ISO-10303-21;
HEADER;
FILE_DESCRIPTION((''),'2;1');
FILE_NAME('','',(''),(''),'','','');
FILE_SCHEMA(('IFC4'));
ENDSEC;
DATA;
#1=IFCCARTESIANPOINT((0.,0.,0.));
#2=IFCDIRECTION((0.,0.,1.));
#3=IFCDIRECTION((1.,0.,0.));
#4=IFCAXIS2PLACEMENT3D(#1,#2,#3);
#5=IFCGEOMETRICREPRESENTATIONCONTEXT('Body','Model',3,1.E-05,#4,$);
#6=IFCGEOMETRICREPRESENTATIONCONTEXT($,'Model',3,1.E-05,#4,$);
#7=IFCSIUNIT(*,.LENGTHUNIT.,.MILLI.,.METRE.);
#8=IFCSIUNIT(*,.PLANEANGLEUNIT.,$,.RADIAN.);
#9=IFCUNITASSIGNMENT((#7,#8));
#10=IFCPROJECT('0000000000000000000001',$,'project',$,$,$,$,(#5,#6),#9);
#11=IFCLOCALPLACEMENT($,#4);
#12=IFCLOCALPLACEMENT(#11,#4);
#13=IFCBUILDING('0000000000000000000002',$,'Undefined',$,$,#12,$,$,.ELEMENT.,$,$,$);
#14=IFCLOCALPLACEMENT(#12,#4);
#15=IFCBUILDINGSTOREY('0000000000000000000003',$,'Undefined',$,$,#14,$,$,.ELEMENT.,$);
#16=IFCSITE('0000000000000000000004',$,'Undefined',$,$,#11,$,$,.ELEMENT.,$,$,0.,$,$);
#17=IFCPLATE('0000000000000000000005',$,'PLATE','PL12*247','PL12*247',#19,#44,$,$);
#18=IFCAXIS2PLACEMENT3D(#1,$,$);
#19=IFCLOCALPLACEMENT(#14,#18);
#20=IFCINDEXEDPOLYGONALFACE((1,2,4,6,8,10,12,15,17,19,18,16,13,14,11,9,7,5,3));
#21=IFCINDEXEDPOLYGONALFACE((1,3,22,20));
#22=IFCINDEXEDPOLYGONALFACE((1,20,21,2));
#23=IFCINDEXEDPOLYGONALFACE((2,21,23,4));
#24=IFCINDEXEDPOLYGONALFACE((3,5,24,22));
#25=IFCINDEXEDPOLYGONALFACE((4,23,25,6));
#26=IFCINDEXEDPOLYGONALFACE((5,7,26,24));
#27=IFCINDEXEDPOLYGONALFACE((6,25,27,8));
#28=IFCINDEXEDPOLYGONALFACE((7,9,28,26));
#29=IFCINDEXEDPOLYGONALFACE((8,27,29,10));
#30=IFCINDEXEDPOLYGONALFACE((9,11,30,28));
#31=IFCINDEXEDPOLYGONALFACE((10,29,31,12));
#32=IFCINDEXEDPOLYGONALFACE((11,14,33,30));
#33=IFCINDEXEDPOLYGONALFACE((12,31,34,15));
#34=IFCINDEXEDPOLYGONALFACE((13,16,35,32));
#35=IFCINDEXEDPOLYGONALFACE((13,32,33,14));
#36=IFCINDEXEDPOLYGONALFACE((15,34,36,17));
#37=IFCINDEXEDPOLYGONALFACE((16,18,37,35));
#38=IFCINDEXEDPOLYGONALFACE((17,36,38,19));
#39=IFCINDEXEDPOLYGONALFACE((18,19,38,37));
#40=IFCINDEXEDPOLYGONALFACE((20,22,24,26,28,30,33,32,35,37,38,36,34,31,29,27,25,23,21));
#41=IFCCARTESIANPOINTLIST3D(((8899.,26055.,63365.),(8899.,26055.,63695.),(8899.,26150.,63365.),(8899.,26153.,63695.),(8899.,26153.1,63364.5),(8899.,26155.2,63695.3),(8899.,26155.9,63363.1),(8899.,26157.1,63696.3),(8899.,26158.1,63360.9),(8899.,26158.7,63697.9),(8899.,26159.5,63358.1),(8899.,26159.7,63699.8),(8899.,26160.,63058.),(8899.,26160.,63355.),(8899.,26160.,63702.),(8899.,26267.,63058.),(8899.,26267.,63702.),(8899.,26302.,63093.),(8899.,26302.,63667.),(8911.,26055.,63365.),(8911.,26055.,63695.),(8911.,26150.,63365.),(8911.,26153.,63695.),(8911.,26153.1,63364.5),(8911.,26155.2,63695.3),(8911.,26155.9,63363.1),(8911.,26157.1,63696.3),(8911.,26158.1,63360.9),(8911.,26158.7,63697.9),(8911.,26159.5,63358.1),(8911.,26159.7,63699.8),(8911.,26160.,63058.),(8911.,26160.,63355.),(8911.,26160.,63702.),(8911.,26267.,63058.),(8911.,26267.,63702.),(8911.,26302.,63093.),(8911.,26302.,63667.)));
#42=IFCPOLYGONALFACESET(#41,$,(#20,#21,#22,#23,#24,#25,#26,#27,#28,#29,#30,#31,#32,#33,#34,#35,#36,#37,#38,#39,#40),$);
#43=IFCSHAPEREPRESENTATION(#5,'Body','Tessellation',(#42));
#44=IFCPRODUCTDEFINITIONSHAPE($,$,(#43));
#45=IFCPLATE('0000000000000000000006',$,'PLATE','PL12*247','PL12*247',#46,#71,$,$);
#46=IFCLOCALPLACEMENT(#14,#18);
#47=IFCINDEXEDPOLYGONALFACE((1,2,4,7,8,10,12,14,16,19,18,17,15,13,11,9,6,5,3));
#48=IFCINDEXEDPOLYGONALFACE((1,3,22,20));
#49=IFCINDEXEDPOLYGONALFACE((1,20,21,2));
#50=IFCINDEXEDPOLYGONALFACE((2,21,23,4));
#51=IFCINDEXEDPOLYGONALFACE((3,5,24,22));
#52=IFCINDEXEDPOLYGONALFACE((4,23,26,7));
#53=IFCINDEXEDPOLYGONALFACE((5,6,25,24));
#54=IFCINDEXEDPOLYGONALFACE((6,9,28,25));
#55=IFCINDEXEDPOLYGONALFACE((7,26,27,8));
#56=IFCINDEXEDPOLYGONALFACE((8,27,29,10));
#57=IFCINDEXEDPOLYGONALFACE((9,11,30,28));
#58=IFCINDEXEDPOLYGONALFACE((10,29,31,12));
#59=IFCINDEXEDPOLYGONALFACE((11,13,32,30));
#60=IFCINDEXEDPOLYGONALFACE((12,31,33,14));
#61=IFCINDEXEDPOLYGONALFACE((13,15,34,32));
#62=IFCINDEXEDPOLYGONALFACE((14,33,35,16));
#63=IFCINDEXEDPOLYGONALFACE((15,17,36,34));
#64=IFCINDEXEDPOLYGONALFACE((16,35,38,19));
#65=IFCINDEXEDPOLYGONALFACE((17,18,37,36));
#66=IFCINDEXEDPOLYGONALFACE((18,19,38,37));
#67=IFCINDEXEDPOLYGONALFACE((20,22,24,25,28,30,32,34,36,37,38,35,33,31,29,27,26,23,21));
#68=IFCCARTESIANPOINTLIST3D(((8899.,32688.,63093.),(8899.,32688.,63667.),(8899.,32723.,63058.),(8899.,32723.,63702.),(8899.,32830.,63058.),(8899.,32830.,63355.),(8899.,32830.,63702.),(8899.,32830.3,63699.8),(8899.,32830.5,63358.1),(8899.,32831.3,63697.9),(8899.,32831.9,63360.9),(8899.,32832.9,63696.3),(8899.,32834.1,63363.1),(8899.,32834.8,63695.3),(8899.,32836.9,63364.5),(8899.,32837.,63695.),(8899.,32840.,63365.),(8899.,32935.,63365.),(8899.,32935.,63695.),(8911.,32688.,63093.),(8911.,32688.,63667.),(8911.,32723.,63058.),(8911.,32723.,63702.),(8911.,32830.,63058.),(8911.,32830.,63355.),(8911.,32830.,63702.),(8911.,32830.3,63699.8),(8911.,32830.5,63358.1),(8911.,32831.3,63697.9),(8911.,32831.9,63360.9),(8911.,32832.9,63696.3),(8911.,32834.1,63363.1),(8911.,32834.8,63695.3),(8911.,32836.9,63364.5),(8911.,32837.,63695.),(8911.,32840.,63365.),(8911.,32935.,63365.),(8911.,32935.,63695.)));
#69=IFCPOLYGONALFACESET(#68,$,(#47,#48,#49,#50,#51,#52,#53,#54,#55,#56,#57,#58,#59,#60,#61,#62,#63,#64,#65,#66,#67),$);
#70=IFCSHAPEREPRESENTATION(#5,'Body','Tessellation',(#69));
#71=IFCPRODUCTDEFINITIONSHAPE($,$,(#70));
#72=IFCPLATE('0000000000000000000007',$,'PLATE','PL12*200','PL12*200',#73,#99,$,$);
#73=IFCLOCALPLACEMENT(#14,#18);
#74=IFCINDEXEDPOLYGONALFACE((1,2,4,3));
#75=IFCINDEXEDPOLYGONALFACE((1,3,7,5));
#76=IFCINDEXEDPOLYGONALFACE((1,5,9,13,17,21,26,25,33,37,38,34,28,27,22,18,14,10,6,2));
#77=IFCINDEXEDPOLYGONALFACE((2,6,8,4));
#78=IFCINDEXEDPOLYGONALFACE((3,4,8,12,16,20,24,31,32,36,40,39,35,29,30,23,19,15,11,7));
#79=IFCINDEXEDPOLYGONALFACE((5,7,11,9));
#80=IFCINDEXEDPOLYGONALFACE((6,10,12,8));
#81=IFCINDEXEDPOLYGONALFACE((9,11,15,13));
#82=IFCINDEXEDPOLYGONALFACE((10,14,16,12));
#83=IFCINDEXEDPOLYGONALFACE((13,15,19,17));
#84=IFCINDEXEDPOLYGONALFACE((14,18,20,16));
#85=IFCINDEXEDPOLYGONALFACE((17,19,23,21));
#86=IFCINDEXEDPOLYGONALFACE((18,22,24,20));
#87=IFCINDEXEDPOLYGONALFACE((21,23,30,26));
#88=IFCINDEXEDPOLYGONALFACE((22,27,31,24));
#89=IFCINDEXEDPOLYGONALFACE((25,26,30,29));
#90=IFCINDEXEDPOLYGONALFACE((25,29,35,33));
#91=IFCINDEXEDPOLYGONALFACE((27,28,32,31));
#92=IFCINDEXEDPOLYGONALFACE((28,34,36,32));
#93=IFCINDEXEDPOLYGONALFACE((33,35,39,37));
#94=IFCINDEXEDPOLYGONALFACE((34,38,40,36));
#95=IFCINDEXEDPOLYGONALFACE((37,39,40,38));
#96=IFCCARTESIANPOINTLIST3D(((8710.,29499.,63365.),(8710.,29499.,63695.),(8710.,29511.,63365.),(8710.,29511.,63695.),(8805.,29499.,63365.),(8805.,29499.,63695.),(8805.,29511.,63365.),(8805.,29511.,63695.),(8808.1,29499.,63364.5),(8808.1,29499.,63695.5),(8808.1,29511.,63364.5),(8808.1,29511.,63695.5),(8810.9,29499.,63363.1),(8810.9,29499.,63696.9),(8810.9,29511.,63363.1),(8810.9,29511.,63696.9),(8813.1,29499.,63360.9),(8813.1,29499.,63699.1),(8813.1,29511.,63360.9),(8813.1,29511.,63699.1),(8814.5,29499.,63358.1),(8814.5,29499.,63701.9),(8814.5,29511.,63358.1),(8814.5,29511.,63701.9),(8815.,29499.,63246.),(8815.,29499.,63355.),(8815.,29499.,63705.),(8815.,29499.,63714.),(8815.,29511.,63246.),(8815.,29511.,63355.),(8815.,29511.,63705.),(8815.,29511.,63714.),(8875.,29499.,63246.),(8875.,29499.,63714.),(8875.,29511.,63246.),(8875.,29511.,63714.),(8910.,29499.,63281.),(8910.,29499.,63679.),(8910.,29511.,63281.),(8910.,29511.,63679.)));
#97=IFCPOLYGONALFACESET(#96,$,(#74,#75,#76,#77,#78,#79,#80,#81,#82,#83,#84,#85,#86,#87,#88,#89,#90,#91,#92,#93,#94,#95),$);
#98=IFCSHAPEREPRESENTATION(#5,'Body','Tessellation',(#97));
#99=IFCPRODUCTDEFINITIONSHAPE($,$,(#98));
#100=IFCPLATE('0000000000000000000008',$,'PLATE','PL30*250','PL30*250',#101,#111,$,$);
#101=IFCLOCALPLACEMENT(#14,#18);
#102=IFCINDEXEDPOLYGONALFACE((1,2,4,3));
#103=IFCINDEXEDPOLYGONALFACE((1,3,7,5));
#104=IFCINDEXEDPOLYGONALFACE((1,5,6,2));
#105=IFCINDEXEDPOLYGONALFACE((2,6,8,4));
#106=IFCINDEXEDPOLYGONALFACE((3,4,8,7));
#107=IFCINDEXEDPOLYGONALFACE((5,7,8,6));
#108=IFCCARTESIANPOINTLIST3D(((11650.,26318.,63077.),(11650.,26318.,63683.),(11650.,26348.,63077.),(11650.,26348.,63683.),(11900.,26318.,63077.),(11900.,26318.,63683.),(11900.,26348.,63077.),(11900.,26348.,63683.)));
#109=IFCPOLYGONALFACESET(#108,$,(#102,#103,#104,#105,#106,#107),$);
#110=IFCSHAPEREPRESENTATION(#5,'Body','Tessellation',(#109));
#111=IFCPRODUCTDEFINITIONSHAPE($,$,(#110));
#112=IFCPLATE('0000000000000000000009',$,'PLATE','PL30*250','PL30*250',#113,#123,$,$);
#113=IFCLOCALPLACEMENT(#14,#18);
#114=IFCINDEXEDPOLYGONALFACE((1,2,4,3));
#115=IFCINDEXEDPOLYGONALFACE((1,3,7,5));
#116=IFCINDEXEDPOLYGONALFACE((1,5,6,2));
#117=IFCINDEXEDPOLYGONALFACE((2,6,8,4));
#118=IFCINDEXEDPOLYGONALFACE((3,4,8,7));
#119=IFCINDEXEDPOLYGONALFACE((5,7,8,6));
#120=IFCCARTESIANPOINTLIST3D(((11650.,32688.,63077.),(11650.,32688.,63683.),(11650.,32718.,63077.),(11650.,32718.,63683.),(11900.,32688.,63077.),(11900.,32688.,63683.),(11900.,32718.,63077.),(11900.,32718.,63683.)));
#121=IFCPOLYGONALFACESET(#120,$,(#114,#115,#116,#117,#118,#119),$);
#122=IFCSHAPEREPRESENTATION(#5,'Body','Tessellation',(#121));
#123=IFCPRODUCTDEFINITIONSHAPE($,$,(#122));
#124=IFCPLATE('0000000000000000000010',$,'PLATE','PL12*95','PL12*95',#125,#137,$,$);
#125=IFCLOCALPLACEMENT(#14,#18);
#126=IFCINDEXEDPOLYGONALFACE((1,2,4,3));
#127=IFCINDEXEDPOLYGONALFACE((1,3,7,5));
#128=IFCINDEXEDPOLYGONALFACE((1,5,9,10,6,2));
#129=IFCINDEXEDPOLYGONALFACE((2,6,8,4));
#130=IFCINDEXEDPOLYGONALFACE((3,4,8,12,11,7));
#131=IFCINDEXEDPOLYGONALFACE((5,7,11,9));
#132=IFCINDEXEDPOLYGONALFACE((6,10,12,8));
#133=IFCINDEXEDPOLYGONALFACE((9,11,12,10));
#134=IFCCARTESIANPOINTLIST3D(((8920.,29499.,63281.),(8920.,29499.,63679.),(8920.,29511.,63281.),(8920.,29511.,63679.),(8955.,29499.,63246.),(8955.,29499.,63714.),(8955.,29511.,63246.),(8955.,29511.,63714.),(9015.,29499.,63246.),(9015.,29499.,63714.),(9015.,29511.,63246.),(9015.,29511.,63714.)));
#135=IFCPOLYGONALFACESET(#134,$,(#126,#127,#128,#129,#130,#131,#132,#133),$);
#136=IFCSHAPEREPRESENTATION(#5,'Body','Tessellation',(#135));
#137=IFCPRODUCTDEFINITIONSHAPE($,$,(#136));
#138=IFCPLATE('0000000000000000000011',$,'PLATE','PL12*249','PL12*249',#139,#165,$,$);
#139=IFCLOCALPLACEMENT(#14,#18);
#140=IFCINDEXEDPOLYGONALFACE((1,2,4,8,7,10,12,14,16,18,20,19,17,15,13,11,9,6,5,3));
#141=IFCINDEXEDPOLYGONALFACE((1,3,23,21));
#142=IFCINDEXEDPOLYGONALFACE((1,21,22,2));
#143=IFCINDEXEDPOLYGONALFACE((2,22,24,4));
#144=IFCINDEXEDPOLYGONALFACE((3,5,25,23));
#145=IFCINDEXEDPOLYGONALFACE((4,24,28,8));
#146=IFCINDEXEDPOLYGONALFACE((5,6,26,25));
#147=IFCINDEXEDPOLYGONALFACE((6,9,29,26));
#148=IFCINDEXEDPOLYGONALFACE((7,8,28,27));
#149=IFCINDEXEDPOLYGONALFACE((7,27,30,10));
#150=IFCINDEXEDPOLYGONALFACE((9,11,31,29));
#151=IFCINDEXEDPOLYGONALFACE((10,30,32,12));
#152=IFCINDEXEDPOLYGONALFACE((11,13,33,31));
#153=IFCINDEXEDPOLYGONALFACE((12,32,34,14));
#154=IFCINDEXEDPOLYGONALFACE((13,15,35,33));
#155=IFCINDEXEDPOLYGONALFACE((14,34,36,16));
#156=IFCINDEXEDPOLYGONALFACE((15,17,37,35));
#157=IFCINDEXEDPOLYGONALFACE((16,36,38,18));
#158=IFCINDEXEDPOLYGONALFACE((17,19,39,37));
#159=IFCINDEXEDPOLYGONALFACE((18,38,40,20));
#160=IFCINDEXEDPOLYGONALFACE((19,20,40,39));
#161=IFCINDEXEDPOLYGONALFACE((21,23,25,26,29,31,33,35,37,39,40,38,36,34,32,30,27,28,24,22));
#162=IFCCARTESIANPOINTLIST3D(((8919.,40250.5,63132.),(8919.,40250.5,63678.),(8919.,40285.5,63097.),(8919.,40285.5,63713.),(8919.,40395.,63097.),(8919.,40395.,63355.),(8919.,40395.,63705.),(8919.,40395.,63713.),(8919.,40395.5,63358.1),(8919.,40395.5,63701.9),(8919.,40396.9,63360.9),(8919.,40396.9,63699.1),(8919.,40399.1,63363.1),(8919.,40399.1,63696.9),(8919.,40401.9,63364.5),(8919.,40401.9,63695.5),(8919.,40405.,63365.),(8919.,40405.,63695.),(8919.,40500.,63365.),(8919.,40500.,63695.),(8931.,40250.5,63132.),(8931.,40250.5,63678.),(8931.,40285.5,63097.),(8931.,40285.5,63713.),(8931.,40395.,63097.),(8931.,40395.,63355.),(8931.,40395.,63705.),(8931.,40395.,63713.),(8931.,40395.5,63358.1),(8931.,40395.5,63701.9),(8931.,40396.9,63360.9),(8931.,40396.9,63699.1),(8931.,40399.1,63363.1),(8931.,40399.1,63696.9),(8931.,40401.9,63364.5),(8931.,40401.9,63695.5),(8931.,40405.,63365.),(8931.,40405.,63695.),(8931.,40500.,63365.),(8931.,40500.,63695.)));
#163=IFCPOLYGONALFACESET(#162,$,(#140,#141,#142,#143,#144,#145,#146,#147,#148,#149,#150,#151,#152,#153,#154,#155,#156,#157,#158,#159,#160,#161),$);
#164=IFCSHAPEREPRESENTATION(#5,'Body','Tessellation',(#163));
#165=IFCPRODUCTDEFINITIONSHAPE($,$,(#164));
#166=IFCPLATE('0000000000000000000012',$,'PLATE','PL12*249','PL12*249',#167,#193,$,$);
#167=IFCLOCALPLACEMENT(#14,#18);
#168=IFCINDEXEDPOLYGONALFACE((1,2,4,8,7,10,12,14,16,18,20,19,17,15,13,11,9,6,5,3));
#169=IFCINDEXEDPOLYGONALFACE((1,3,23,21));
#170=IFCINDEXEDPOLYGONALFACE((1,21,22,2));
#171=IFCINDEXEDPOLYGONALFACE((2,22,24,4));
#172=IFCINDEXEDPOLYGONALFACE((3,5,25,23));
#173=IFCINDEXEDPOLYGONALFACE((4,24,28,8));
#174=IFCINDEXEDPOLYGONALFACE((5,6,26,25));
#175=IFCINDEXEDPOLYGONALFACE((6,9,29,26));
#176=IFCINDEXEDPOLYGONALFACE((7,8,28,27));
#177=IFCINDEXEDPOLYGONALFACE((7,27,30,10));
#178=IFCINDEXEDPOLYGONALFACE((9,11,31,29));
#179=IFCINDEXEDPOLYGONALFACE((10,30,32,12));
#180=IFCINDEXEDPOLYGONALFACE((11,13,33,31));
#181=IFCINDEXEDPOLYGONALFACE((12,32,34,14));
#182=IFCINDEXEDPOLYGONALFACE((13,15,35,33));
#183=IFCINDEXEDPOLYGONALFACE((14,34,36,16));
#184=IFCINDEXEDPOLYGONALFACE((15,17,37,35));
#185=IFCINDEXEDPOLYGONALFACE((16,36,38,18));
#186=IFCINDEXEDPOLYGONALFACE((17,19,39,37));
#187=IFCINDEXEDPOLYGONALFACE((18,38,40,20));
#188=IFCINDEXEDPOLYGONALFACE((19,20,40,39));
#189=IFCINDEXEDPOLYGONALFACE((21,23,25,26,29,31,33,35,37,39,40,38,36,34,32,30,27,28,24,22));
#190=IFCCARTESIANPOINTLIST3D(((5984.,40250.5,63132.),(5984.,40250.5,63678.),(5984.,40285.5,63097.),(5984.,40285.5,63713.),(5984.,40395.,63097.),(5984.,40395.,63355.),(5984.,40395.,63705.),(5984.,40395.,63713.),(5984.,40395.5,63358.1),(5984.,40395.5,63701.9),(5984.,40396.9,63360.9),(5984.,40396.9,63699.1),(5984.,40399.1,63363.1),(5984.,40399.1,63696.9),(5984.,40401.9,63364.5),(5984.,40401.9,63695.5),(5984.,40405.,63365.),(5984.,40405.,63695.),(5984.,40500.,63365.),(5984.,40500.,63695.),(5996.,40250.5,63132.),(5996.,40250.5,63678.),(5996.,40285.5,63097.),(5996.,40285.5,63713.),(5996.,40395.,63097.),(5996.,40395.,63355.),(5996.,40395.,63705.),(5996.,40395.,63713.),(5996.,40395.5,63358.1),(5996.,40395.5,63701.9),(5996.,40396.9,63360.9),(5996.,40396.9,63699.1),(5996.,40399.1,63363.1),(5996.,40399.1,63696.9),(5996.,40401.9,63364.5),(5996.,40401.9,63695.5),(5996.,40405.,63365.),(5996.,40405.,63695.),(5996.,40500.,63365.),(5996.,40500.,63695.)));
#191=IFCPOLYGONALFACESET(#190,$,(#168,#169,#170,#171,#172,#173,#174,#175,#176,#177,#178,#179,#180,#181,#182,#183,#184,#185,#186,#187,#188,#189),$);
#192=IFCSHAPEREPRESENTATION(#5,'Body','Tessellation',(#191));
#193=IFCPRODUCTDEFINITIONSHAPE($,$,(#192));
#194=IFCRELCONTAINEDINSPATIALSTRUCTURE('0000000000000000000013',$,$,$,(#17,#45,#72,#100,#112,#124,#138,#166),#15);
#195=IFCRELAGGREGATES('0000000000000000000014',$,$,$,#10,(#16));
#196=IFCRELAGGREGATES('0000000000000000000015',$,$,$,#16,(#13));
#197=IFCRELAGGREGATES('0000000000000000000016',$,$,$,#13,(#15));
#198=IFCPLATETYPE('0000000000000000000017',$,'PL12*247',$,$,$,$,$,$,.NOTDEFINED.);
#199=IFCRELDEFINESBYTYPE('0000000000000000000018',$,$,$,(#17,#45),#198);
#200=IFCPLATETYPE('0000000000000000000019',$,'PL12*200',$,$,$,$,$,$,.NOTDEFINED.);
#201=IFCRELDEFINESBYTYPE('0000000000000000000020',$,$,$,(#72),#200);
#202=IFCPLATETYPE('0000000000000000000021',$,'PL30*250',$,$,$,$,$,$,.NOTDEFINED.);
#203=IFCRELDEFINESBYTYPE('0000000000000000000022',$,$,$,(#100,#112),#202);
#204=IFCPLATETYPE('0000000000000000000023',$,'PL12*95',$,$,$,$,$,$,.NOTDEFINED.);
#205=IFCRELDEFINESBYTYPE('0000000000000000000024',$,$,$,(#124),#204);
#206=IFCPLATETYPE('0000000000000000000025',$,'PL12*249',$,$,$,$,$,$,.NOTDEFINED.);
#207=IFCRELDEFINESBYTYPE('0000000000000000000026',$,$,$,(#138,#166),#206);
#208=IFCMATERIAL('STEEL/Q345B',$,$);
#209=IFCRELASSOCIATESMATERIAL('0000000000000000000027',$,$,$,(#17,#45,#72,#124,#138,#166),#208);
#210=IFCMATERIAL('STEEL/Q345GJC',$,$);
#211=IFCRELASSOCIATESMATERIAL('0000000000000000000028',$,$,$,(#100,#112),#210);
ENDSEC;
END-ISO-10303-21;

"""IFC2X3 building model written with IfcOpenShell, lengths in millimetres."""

from ifc_helpers import new_model, si_unit, frame, origin_with_axes, place, context, project, spatial, polyline, outline, extrude, material, type_object, element, save


model = new_model("IFC2X3")

# Units and contexts
model_context_1 = context("Model", 3, precision=1e-05, world=origin_with_axes(), identifier="Body")
model_context_2 = context("Model", 3, precision=1e-05, world=origin_with_axes())
ifc_project = project(units=[si_unit("LENGTHUNIT", "METRE", prefix="MILLI"), si_unit("PLANEANGLEUNIT", "RADIAN")], contexts=[model_context_1, model_context_2])

# Site, building, storey
site_placement = place(None, origin_with_axes())
site = spatial("IfcSite", under=ifc_project, at=site_placement, Name="Undefined", CompositionType="ELEMENT", RefElevation=0.0)
building_placement = place(site_placement, origin_with_axes())
building = spatial("IfcBuilding", under=site, at=building_placement, Name="Undefined", CompositionType="ELEMENT")
storey_placement = place(building_placement, origin_with_axes())
storey = spatial("IfcBuildingStorey", under=building, at=storey_placement, Name="Undefined", CompositionType="ELEMENT")

# Shared definitions
ifc_material_1 = material(Name="STEEL/Q345B")

# Shared definitions
ifc_material_2 = material(Name="STEEL/Q345GJC")

# Plates
plate_type_1 = type_object("IfcPlateType", Name="PL12*247", PredefinedType="NOTDEFINED")
for number, where, z_axis, x_axis, name in (
    (1, (8905.0, 26302.0, 63093.0), (-1.0, 0.0, 0.0), (0.0, -0.707107, -0.707107), "PLATE"),
    (2, (8905.0, 32688.0, 63093.0), (1.0, 0.0, 0.0), (0.0, 0.707107, -0.707107), "PLATE"),
):
    element("IfcPlate", number, at=place(storey_placement, frame(where, z_axis=z_axis, x_axis=x_axis)), inside=storey, type_object=plate_type_1, material=ifc_material_1, Name=name, Description="PL12*247", ObjectType="PL12*247", context=model_context_1, shape_type="SweptSolid", body=[
        extrude(outline(polyline([(0.0, 0.0), (49.5, 0.0), (125.2, 75.7), (-84.9, 285.7), (-86.7, 288.2), (-87.7, 291.2), (-87.7, 294.3), (-86.7, 297.3), (-84.9, 299.8), (-17.7, 367.0), (-251.0, 600.3), (-320.3, 531.0), (-322.1, 529.7), (-324.2, 529.1), (-326.4, 529.1), (-328.4, 529.7), (-330.2, 531.0), (-405.9, 455.4), (-405.9, 405.9), (0.0, 0.0)])), frame((0.0, 0.0, -6.0), z_axis=(0.0, 0.0, 1.0), x_axis=(1.0, 0.0, 0.0)), (0.0, 0.0, 1.0), 12.0),
    ])
plate_type_2 = type_object("IfcPlateType", Name="PL12*200", PredefinedType="NOTDEFINED")
for number, where, z_axis, x_axis, name in (
    (3, (8910.0, 29505.0, 63281.0), (0.0, 1.0, 0.0), (-0.707107, 0.0, -0.707107), "PLATE"),
):
    element("IfcPlate", number, at=place(storey_placement, frame(where, z_axis=z_axis, x_axis=x_axis)), inside=storey, type_object=plate_type_2, material=ifc_material_1, Name=name, Description="PL12*200", ObjectType="PL12*200", context=model_context_1, shape_type="SweptSolid", body=[
        extrude(outline(polyline([(0.0, 0.0), (49.5, 0.0), (91.9, 42.4), (14.8, 119.5), (13.0, 122.0), (12.0, 125.0), (12.0, 128.1), (13.0, 131.1), (14.8, 133.6), (82.0, 200.8), (-151.3, 434.2), (-218.5, 367.0), (-221.0, 365.1), (-224.0, 364.2), (-227.1, 364.2), (-230.1, 365.1), (-232.6, 367.0), (-239.0, 373.4), (-281.4, 330.9), (-281.4, 281.4), (0.0, 0.0)])), frame((0.0, 0.0, -6.0), z_axis=(0.0, 0.0, 1.0), x_axis=(1.0, 0.0, 0.0)), (0.0, 0.0, 1.0), 12.0),
    ])
plate_type_3 = type_object("IfcPlateType", Name="PL30*250", PredefinedType="NOTDEFINED")
for number, where, z_axis, x_axis, name in (
    (4, (11650.0, 26333.0, 63683.0), (0.0, 1.0, 0.0), (1.0, 0.0, 0.0), "PLATE"),
    (5, (11650.0, 32703.0, 63683.0), (0.0, 1.0, 0.0), (1.0, 0.0, 0.0), "PLATE"),
):
    element("IfcPlate", number, at=place(storey_placement, frame(where, z_axis=z_axis, x_axis=x_axis)), inside=storey, type_object=plate_type_3, material=ifc_material_2, Name=name, Description="PL30*250", ObjectType="PL30*250", context=model_context_1, shape_type="SweptSolid", body=[
        extrude(outline(polyline([(0.0, 0.0), (250.0, 0.0), (250.0, 606.0), (0.0, 606.0), (0.0, 0.0)])), frame((0.0, 0.0, -15.0), z_axis=(0.0, 0.0, 1.0), x_axis=(1.0, 0.0, 0.0)), (0.0, 0.0, 1.0), 30.0),
    ])
plate_type_4 = type_object("IfcPlateType", Name="PL12*95", PredefinedType="NOTDEFINED")
plate_1_placement = place(storey_placement, frame((8920.0, 29505.0, 63246.0), z_axis=(0.0, -1.0, 0.0), x_axis=(1.0, 0.0, 0.0)))
element("IfcPlate", 6, at=plate_1_placement, inside=storey, type_object=plate_type_4, material=ifc_material_1, Name="PLATE", Description="PL12*95", ObjectType="PL12*95", context=model_context_1, shape_type="SweptSolid", body=[
    extrude(outline(polyline([(0.0, 35.0), (35.0, 0.0), (95.0, 0.0), (95.0, 468.0), (35.0, 468.0), (0.0, 433.0), (0.0, 35.0)])), frame((0.0, 0.0, -6.0), z_axis=(0.0, 0.0, 1.0), x_axis=(1.0, 0.0, 0.0)), (0.0, 0.0, 1.0), 12.0),
])
plate_type_5 = type_object("IfcPlateType", Name="PL12*249", PredefinedType="NOTDEFINED")
for number, where, z_axis, x_axis, name in (
    (7, (8925.0, 40250.5, 63132.0), (1.0, 0.0, 0.0), (0.0, 0.707107, -0.707107), "PLATE"),
    (8, (5990.0, 40250.5, 63132.0), (1.0, 0.0, 0.0), (0.0, 0.707107, -0.707107), "PLATE"),
):
    element("IfcPlate", number, at=place(storey_placement, frame(where, z_axis=z_axis, x_axis=x_axis)), inside=storey, type_object=plate_type_5, material=ifc_material_1, Name=name, Description="PL12*249", ObjectType="PL12*249", context=model_context_1, shape_type="SweptSolid", body=[
        extrude(outline(polyline([(0.0, 0.0), (49.5, 0.0), (126.9, 77.4), (-55.5, 259.9), (-57.3, 262.4), (-58.3, 265.4), (-58.3, 268.5), (-57.3, 271.5), (-55.5, 274.0), (11.7, 341.2), (-221.7, 574.5), (-288.9, 507.3), (-291.4, 505.5), (-294.4, 504.5), (-297.5, 504.5), (-300.5, 505.5), (-303.0, 507.3), (-308.7, 513.0), (-386.1, 435.6), (-386.1, 386.1), (0.0, 0.0)])), frame((0.0, 0.0, -6.0), z_axis=(0.0, 0.0, 1.0), x_axis=(1.0, 0.0, 0.0)), (0.0, 0.0, 1.0), 12.0),
    ])

save(model, "model.ifc")
